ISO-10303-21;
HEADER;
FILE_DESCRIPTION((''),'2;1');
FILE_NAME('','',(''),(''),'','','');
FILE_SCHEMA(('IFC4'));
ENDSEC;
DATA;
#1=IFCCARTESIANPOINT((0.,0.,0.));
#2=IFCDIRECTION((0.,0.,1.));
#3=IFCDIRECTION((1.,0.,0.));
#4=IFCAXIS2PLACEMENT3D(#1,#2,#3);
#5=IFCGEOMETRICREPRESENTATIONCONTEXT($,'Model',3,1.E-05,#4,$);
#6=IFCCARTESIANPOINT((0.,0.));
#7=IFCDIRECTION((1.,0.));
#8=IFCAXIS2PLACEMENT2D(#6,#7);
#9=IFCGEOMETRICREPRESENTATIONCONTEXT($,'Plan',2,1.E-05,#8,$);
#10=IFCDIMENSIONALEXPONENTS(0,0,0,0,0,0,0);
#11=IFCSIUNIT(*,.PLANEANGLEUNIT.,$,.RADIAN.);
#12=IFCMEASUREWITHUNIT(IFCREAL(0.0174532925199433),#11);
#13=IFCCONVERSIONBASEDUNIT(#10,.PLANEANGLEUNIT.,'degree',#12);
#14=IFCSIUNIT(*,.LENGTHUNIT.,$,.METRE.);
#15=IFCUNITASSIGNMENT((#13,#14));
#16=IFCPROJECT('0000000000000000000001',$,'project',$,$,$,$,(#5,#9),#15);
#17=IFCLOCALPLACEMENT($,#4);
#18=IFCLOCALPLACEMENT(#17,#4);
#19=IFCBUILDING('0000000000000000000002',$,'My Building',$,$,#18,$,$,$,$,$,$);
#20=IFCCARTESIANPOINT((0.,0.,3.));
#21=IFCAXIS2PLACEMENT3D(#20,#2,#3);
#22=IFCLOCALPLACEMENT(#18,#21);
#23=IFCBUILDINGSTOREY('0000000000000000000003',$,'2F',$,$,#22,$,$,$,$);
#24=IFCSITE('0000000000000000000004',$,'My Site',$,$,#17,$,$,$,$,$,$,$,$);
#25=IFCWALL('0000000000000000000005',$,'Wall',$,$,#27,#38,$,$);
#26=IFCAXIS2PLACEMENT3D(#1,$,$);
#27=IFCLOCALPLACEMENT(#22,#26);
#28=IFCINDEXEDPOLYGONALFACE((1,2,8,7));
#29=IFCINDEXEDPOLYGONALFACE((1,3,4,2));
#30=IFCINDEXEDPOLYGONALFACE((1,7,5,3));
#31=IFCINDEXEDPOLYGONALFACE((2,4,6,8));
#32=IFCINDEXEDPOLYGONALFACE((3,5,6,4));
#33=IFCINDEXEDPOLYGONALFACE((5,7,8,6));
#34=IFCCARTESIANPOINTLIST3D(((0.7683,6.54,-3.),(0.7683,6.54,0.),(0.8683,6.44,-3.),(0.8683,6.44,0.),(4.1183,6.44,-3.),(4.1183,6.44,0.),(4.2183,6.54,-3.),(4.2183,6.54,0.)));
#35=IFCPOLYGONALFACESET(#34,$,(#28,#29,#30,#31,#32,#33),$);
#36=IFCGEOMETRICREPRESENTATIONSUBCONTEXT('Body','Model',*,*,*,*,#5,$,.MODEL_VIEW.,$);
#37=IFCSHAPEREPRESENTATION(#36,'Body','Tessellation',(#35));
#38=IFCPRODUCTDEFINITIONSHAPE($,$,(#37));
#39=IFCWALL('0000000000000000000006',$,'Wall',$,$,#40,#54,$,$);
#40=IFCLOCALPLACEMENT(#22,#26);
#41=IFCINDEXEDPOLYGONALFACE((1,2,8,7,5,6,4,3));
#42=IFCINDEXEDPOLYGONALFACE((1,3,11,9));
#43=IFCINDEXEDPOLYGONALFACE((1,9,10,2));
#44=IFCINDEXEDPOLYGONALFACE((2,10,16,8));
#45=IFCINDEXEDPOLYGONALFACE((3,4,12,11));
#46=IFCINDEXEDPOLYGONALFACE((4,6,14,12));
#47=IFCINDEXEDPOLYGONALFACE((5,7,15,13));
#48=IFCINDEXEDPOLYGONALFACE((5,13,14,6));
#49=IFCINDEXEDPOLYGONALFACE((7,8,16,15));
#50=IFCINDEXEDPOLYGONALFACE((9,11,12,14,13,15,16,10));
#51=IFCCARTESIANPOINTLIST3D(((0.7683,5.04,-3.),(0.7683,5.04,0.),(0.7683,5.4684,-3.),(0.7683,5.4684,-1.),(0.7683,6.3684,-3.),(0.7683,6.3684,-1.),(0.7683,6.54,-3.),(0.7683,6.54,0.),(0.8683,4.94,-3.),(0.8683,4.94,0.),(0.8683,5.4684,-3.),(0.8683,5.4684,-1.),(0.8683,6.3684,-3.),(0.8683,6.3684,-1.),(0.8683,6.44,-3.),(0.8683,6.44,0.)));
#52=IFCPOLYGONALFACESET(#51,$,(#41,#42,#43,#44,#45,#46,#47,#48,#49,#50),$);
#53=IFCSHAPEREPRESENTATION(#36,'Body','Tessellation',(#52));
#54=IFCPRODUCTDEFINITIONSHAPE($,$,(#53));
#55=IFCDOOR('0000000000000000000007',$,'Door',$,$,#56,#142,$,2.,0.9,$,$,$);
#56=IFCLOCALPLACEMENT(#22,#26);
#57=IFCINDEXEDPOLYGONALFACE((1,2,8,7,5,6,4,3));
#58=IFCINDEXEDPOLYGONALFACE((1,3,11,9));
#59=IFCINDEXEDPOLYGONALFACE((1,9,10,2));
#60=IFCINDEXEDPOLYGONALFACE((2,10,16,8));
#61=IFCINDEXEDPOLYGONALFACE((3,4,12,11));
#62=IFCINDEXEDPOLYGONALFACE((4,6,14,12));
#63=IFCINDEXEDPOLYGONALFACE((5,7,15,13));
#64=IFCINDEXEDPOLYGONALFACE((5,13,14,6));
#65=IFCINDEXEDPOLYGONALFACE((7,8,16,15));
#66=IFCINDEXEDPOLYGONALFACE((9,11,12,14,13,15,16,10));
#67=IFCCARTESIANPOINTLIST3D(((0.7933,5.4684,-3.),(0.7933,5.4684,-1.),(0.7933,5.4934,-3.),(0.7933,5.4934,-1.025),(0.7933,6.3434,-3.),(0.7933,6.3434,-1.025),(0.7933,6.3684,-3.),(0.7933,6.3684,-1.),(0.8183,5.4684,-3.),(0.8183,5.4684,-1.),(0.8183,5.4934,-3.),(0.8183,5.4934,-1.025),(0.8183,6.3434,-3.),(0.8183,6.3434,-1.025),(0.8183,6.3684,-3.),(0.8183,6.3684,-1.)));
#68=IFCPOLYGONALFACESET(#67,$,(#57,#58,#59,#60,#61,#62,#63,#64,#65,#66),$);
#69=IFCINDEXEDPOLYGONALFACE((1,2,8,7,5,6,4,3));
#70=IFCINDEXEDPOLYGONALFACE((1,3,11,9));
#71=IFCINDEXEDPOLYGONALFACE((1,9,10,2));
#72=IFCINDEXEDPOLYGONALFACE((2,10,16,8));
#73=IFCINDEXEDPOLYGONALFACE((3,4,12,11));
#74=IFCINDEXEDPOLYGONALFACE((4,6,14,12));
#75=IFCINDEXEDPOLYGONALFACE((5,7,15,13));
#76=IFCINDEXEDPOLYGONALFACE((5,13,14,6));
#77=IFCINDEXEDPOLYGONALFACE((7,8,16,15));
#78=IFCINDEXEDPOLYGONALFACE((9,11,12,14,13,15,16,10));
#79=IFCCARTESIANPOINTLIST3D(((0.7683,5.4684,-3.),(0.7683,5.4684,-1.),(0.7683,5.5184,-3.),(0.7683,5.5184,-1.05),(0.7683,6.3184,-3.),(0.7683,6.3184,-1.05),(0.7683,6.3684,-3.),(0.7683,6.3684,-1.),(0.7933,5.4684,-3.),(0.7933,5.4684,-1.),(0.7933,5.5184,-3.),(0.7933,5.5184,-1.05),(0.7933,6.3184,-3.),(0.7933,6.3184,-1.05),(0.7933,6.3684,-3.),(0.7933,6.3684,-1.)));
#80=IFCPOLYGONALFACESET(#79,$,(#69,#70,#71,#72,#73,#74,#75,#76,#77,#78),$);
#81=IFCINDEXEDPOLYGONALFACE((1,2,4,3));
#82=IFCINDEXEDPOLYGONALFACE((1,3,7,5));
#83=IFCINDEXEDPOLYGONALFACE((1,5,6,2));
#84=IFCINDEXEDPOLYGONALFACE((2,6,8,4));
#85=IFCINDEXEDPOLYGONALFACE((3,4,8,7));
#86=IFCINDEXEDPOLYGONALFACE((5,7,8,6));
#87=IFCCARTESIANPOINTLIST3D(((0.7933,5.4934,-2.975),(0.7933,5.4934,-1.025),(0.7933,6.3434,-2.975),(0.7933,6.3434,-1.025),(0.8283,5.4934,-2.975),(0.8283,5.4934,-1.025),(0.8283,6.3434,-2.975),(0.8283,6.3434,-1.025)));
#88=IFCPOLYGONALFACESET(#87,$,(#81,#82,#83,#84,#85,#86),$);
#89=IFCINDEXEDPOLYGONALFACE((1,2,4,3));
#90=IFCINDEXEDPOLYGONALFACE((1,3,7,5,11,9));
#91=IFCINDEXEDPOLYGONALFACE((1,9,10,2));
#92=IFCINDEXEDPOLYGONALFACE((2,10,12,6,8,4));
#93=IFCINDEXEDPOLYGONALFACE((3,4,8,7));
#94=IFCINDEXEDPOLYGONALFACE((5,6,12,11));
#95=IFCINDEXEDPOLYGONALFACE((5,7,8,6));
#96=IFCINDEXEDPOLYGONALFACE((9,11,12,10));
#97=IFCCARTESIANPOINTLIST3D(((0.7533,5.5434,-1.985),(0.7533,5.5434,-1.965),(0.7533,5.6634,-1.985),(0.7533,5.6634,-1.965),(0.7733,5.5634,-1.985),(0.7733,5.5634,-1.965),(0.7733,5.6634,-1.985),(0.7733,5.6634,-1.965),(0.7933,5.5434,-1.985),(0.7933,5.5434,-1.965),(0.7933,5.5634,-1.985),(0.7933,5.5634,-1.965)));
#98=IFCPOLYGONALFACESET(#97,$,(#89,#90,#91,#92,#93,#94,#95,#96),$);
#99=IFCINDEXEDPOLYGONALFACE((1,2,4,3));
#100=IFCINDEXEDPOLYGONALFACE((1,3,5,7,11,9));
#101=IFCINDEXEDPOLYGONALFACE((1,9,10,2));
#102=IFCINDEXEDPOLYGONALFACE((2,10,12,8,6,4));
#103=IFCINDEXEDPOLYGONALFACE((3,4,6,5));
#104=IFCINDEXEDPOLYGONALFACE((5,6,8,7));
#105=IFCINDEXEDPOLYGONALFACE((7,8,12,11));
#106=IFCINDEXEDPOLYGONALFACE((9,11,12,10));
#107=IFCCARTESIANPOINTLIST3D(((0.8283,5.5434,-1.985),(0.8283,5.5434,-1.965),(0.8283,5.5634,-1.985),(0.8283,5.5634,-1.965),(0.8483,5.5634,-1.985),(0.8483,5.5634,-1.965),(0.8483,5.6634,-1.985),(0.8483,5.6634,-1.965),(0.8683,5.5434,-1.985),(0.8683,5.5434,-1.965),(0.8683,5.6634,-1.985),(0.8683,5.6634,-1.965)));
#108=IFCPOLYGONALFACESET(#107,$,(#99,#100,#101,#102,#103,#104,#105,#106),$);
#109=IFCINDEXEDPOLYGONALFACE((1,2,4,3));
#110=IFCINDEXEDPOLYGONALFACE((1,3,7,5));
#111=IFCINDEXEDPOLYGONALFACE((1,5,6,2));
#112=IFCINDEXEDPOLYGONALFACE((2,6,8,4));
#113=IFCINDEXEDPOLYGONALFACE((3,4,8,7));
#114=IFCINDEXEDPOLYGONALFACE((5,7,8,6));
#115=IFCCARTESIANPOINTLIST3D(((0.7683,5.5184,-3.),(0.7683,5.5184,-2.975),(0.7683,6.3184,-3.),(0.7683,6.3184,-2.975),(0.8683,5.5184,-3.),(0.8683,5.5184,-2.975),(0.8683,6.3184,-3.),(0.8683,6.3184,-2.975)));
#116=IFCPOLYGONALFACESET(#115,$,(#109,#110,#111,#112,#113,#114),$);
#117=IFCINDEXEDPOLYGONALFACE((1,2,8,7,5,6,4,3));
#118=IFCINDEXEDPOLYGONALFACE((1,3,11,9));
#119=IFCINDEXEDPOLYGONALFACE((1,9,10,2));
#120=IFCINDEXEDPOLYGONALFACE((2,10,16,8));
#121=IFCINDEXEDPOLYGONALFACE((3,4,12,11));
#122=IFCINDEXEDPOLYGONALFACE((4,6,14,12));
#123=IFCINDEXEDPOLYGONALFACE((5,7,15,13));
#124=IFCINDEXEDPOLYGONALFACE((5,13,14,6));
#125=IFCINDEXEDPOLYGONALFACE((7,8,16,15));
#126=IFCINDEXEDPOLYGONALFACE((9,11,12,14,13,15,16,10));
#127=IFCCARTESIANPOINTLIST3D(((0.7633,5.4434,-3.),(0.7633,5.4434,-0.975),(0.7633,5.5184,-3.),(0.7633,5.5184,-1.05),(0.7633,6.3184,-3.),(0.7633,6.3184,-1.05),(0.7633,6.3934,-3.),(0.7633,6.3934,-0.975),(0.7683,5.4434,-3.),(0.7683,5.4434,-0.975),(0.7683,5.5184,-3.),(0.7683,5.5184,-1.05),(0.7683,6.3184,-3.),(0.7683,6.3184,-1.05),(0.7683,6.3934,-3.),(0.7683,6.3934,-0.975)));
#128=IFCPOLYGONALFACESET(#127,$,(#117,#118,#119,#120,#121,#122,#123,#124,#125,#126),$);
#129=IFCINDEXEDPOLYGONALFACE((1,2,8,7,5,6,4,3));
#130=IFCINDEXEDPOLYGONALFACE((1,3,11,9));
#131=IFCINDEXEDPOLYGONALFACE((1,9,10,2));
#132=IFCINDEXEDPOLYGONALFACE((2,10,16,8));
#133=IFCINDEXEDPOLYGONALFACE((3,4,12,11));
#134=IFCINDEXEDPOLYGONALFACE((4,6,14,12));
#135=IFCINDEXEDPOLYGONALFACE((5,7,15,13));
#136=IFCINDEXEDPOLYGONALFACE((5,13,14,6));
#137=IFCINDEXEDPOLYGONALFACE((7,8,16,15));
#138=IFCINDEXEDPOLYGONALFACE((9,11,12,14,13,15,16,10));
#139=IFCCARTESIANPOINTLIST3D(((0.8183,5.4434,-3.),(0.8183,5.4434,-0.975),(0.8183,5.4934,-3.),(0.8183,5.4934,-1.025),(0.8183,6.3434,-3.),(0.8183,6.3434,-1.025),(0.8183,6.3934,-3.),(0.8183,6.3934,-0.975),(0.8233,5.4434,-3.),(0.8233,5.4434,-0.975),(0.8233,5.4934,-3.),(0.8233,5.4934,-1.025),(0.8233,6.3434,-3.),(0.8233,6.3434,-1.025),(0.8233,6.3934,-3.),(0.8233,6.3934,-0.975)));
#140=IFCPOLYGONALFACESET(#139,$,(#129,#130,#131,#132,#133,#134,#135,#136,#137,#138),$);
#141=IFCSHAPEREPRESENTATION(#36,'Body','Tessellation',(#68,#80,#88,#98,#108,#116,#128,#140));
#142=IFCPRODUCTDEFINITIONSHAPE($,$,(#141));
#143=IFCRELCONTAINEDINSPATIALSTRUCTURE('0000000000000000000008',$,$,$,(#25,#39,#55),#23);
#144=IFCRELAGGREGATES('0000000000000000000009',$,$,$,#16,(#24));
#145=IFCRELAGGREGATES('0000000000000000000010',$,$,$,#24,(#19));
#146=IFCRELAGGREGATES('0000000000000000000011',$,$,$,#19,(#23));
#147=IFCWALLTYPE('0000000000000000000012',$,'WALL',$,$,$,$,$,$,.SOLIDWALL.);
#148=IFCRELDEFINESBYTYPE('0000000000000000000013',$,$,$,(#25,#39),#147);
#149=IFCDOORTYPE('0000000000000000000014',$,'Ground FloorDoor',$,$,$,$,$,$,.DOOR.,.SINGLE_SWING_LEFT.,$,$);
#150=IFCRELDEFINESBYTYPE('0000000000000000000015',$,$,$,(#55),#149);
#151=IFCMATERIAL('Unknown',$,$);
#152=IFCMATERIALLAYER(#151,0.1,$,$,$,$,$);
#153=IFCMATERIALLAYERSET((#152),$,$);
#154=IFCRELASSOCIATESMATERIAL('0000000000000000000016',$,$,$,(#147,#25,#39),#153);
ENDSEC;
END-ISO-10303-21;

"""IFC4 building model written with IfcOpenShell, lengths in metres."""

from ifc_helpers import new_model, entity, si_unit, converted_unit, frame, origin_with_axes, origin_2d_with_axis, place, context, subcontext, project, spatial, line, indexed_curve, outline, extrude, shape, source, transform, mapped, material, layer, layer_set, layer_usage, type_object, type_shapes, element, fill, save


model = new_model("IFC4")

# Units and contexts
model_context = context("Model", 3, precision=1e-05, world=origin_with_axes())
plan_context = context("Plan", 2, precision=1e-05, world=origin_2d_with_axis())
body_context_1 = subcontext(model_context, "Body", "Model", "MODEL_VIEW")
body_context_2 = subcontext(plan_context, "Body", "Plan", "PLAN_VIEW")
ifc_project = project(units=[converted_unit("PLANEANGLEUNIT", "degree", entity("IfcReal", 0.0174532925199433), si_unit("PLANEANGLEUNIT", "RADIAN"), dimensions=[0, 0, 0, 0, 0, 0, 0]), si_unit("LENGTHUNIT", "METRE")], contexts=[model_context, plan_context])

# Site, building, storey
site_placement = place(None, origin_with_axes())
site = spatial("IfcSite", under=ifc_project, at=site_placement, Name="My Site")
building_placement = place(site_placement, origin_with_axes())
building = spatial("IfcBuilding", under=site, at=building_placement, Name="My Building")
storey_placement = place(building_placement, frame((0.0, 0.0, 3.0), z_axis=(0.0, 0.0, 1.0), x_axis=(1.0, 0.0, 0.0)))
storey = spatial("IfcBuildingStorey", under=building, at=storey_placement, Name="2F")

# Wall
ifc_material = material(Name="Unknown")
ifc_layer_1 = layer(ifc_material, 0.1)
ifc_layer_set_1 = layer_set([ifc_layer_1])
ifc_layer_usage_1 = layer_usage(ifc_layer_set_1, "AXIS2", "POSITIVE", 0.0)
wall_type_1 = type_object("IfcWallType", Name="WALL", PredefinedType="SOLIDWALL", material=ifc_layer_set_1)
wall_1_placement = place(storey_placement, frame((4.2183, 6.54, -3.0), z_axis=(0.0, 0.0, 1.0), x_axis=(-1.0, 0.0, 0.0)))
element("IfcWall", 1, at=wall_1_placement, inside=storey, type_object=wall_type_1, material=ifc_layer_usage_1, Name="Wall", context=body_context_1, shape_type="SweptSolid", body=[
    extrude(outline(indexed_curve([(0.0, 0.0), (0.1, 0.1), (3.35, 0.1), (3.45, 0.0)], segments=[line(1, 2, 3, 4, 1)])), origin_with_axes(), (0.0, 0.0, 1.0), 3.0),
])

# Wall, opening, door
ifc_layer_usage_2 = layer_usage(ifc_layer_set_1, "AXIS2", "POSITIVE", 0.0)
wall_2_placement = place(storey_placement, frame((0.7683, 6.54, -3.0), z_axis=(0.0, 0.0, 1.0), x_axis=(0.0, -1.0, 0.0)))
wall_2 = element("IfcWall", 2, at=wall_2_placement, inside=storey, type_object=wall_type_1, material=ifc_layer_usage_2, Name="Wall", context=body_context_1, shape_type="SweptSolid", body=[
    extrude(outline(indexed_curve([(0.0, 0.0), (0.1, 0.1), (1.6, 0.1), (1.5, 0.0)], segments=[line(1, 2, 3, 4, 1)])), origin_with_axes(), (0.0, 0.0, 1.0), 3.0),
])
shared_shape_1 = source(origin_with_axes(), body_context_1, "Body", "SweptSolid", [
    extrude(outline(indexed_curve([(0.0, 0.0), (0.9, 0.0), (0.9, 2.0), (0.0, 2.0)], segments=[line(1, 2, 3, 4, 1)])), frame((0.0, -0.6, 0.0), z_axis=(0.0, -1.0, 0.0), x_axis=(1.0, 0.0, 0.0)), (0.0, 0.0, -1.0), 1.2),
])
opening_1_placement = place(wall_2_placement, frame((0.1715, 0.0, 0.0), z_axis=(0.0, 0.0, 1.0), x_axis=(1.0, 0.0, 0.0)))
opening_1 = element("IfcOpeningElement", 3, at=opening_1_placement, cuts=wall_2, PredefinedType="OPENING", context=body_context_1, shape_type="MappedRepresentation", body=[
    mapped(shared_shape_1, transform((0.0, 0.0, 0.0), x_axis=(1.0, 0.0, 0.0), y_axis=(0.0, 1.0, 0.0), z_axis=(0.0, 0.0, 1.0), scale=1.0)),
])
door_type_1 = type_object("IfcDoorType", Name="Ground FloorDoor", OperationType="SINGLE_SWING_LEFT", PredefinedType="DOOR")
shared_shape_2 = source(origin_with_axes(), body_context_1, "Body", "SweptSolid", [
    extrude(outline(indexed_curve([(0.0, 0.0), (0.0, 2.0), (0.9, 2.0), (0.9, 0.0), (0.875, 0.0), (0.875, 1.975), (0.025, 1.975), (0.025, 0.0)], segments=[line(1, 2, 3, 4, 5, 6, 7, 8, 1)])), frame((0.0, 0.025, 0.0), z_axis=(0.0, -1.0, 0.0), x_axis=(1.0, 0.0, 0.0)), (0.0, 0.0, -1.0), 0.025),
    extrude(outline(indexed_curve([(0.0, 0.0), (0.0, 2.0), (0.9, 2.0), (0.9, 0.0), (0.85, 0.0), (0.85, 1.95), (0.05, 1.95), (0.05, 0.0)], segments=[line(1, 2, 3, 4, 5, 6, 7, 8, 1)])), frame((0.0, 0.0, 0.0), z_axis=(0.0, -1.0, 0.0), x_axis=(1.0, 0.0, 0.0)), (0.0, 0.0, -1.0), 0.025),
    extrude(outline(indexed_curve([(0.0, 0.0), (0.85, 0.0), (0.85, 0.035), (0.0, 0.035)], segments=[line(1, 2, 3, 4, 1)])), frame((0.025, 0.025, 0.025), z_axis=(0.0, 0.0, 1.0), x_axis=(1.0, 0.0, 0.0)), (0.0, 0.0, 1.0), 1.95),
    extrude(outline(indexed_curve([(0.0, 0.0), (0.0, -0.04), (-0.12, -0.04), (-0.12, -0.02), (-0.02, -0.02), (-0.02, 0.0)], segments=[line(1, 2, 3, 4, 5, 6, 1)])), frame((0.825, 0.025, 1.015), z_axis=(0.0, 0.0, 1.0), x_axis=(1.0, 0.0, 0.0)), (0.0, 0.0, 1.0), 0.02),
    extrude(outline(indexed_curve([(0.0, 0.0), (0.0, 0.04), (-0.12, 0.04), (-0.12, 0.02), (-0.02, 0.02), (-0.02, 0.0)], segments=[line(1, 2, 3, 4, 5, 6, 1)])), frame((0.825, 0.06, 1.015), z_axis=(0.0, 0.0, 1.0), x_axis=(1.0, 0.0, 0.0)), (0.0, 0.0, 1.0), 0.02),
    extrude(outline(indexed_curve([(0.0, 0.0), (0.8, 0.0), (0.8, 0.1), (0.0, 0.1)], segments=[line(1, 2, 3, 4, 1)])), frame((0.05, 0.0, 0.0), z_axis=(0.0, 0.0, 1.0), x_axis=(1.0, 0.0, 0.0)), (0.0, 0.0, 1.0), 0.025),
    extrude(outline(indexed_curve([(0.0, 0.0), (0.0, 2.025), (0.95, 2.025), (0.95, 0.0), (0.875, 0.0), (0.875, 1.95), (0.075, 1.95), (0.075, 0.0)], segments=[line(1, 2, 3, 4, 5, 6, 7, 8, 1)])), frame((-0.025, -0.005, 0.0), z_axis=(0.0, -1.0, 0.0), x_axis=(1.0, 0.0, 0.0)), (0.0, 0.0, -1.0), 0.005),
    extrude(outline(indexed_curve([(0.0, 0.0), (0.0, 2.025), (0.95, 2.025), (0.95, 0.0), (0.9, 0.0), (0.9, 1.975), (0.05, 1.975), (0.05, 0.0)], segments=[line(1, 2, 3, 4, 5, 6, 7, 8, 1)])), frame((-0.025, 0.05, 0.0), z_axis=(0.0, -1.0, 0.0), x_axis=(1.0, 0.0, 0.0)), (0.0, 0.0, -1.0), 0.005),
])
shared_shape_3 = source(origin_with_axes(), body_context_2, "Body", "Curve2D", [
    entity("IfcIndexedPolyCurve", entity("IfcCartesianPointList2D", [[0.0, 0.0], [0.0, 0.05], [0.025, 0.05], [0.025, 0.025], [0.05, 0.025], [0.05, 0.0]]), [entity("IfcLineIndex", [1, 2, 3, 4, 5, 6, 1])]),
    entity("IfcIndexedPolyCurve", entity("IfcCartesianPointList2D", [[0.9, 0.0], [0.9, 0.05], [0.875, 0.05], [0.875, 0.025], [0.85, 0.025], [0.85, 0.0]]), [entity("IfcLineIndex", [1, 2, 3, 4, 5, 6, 1])]),
    entity("IfcTrimmedCurve", entity("IfcEllipse", entity("IfcAxis2Placement2D", entity("IfcCartesianPoint", [0.06, 0.05]), entity("IfcDirection", [1.0, 0.0])), 0.815, 0.85), [entity("IfcCartesianPoint", [0.875, 0.05])], [entity("IfcCartesianPoint", [0.06, 0.9])], True, "CARTESIAN"),
    entity("IfcIndexedPolyCurve", entity("IfcCartesianPointList2D", [[0.025, 0.05], [0.06, 0.05], [0.06, 0.9], [0.025, 0.9]]), [entity("IfcLineIndex", [1, 2, 3, 4, 1])]),
])
type_shapes(door_type_1, [shared_shape_2, shared_shape_3])
door_1_placement = place(opening_1_placement, frame((0.0, 0.0, 0.0), z_axis=(0.0, 0.0, 1.0), x_axis=(1.0, 0.0, 0.0)))
door_1 = element("IfcDoor", 4, at=door_1_placement, inside=storey, type_object=door_type_1, Name="Door", OverallHeight=2.0, OverallWidth=0.9, shapes=[
    shape(body_context_1, "Body", "MappedRepresentation", [mapped(shared_shape_2, transform((0.0, 0.0, 0.0), x_axis=(1.0, 0.0, 0.0), y_axis=(0.0, 1.0, 0.0), z_axis=(0.0, 0.0, 1.0), scale=1.0))]),
    shape(body_context_2, "Body", "MappedRepresentation", [mapped(shared_shape_3, transform((0.0, 0.0, 0.0), x_axis=(1.0, 0.0, 0.0), y_axis=(0.0, 1.0, 0.0), z_axis=(0.0, 0.0, 1.0), scale=1.0))]),
])
fill(opening_1, door_1)

save(model, "model.ifc")
